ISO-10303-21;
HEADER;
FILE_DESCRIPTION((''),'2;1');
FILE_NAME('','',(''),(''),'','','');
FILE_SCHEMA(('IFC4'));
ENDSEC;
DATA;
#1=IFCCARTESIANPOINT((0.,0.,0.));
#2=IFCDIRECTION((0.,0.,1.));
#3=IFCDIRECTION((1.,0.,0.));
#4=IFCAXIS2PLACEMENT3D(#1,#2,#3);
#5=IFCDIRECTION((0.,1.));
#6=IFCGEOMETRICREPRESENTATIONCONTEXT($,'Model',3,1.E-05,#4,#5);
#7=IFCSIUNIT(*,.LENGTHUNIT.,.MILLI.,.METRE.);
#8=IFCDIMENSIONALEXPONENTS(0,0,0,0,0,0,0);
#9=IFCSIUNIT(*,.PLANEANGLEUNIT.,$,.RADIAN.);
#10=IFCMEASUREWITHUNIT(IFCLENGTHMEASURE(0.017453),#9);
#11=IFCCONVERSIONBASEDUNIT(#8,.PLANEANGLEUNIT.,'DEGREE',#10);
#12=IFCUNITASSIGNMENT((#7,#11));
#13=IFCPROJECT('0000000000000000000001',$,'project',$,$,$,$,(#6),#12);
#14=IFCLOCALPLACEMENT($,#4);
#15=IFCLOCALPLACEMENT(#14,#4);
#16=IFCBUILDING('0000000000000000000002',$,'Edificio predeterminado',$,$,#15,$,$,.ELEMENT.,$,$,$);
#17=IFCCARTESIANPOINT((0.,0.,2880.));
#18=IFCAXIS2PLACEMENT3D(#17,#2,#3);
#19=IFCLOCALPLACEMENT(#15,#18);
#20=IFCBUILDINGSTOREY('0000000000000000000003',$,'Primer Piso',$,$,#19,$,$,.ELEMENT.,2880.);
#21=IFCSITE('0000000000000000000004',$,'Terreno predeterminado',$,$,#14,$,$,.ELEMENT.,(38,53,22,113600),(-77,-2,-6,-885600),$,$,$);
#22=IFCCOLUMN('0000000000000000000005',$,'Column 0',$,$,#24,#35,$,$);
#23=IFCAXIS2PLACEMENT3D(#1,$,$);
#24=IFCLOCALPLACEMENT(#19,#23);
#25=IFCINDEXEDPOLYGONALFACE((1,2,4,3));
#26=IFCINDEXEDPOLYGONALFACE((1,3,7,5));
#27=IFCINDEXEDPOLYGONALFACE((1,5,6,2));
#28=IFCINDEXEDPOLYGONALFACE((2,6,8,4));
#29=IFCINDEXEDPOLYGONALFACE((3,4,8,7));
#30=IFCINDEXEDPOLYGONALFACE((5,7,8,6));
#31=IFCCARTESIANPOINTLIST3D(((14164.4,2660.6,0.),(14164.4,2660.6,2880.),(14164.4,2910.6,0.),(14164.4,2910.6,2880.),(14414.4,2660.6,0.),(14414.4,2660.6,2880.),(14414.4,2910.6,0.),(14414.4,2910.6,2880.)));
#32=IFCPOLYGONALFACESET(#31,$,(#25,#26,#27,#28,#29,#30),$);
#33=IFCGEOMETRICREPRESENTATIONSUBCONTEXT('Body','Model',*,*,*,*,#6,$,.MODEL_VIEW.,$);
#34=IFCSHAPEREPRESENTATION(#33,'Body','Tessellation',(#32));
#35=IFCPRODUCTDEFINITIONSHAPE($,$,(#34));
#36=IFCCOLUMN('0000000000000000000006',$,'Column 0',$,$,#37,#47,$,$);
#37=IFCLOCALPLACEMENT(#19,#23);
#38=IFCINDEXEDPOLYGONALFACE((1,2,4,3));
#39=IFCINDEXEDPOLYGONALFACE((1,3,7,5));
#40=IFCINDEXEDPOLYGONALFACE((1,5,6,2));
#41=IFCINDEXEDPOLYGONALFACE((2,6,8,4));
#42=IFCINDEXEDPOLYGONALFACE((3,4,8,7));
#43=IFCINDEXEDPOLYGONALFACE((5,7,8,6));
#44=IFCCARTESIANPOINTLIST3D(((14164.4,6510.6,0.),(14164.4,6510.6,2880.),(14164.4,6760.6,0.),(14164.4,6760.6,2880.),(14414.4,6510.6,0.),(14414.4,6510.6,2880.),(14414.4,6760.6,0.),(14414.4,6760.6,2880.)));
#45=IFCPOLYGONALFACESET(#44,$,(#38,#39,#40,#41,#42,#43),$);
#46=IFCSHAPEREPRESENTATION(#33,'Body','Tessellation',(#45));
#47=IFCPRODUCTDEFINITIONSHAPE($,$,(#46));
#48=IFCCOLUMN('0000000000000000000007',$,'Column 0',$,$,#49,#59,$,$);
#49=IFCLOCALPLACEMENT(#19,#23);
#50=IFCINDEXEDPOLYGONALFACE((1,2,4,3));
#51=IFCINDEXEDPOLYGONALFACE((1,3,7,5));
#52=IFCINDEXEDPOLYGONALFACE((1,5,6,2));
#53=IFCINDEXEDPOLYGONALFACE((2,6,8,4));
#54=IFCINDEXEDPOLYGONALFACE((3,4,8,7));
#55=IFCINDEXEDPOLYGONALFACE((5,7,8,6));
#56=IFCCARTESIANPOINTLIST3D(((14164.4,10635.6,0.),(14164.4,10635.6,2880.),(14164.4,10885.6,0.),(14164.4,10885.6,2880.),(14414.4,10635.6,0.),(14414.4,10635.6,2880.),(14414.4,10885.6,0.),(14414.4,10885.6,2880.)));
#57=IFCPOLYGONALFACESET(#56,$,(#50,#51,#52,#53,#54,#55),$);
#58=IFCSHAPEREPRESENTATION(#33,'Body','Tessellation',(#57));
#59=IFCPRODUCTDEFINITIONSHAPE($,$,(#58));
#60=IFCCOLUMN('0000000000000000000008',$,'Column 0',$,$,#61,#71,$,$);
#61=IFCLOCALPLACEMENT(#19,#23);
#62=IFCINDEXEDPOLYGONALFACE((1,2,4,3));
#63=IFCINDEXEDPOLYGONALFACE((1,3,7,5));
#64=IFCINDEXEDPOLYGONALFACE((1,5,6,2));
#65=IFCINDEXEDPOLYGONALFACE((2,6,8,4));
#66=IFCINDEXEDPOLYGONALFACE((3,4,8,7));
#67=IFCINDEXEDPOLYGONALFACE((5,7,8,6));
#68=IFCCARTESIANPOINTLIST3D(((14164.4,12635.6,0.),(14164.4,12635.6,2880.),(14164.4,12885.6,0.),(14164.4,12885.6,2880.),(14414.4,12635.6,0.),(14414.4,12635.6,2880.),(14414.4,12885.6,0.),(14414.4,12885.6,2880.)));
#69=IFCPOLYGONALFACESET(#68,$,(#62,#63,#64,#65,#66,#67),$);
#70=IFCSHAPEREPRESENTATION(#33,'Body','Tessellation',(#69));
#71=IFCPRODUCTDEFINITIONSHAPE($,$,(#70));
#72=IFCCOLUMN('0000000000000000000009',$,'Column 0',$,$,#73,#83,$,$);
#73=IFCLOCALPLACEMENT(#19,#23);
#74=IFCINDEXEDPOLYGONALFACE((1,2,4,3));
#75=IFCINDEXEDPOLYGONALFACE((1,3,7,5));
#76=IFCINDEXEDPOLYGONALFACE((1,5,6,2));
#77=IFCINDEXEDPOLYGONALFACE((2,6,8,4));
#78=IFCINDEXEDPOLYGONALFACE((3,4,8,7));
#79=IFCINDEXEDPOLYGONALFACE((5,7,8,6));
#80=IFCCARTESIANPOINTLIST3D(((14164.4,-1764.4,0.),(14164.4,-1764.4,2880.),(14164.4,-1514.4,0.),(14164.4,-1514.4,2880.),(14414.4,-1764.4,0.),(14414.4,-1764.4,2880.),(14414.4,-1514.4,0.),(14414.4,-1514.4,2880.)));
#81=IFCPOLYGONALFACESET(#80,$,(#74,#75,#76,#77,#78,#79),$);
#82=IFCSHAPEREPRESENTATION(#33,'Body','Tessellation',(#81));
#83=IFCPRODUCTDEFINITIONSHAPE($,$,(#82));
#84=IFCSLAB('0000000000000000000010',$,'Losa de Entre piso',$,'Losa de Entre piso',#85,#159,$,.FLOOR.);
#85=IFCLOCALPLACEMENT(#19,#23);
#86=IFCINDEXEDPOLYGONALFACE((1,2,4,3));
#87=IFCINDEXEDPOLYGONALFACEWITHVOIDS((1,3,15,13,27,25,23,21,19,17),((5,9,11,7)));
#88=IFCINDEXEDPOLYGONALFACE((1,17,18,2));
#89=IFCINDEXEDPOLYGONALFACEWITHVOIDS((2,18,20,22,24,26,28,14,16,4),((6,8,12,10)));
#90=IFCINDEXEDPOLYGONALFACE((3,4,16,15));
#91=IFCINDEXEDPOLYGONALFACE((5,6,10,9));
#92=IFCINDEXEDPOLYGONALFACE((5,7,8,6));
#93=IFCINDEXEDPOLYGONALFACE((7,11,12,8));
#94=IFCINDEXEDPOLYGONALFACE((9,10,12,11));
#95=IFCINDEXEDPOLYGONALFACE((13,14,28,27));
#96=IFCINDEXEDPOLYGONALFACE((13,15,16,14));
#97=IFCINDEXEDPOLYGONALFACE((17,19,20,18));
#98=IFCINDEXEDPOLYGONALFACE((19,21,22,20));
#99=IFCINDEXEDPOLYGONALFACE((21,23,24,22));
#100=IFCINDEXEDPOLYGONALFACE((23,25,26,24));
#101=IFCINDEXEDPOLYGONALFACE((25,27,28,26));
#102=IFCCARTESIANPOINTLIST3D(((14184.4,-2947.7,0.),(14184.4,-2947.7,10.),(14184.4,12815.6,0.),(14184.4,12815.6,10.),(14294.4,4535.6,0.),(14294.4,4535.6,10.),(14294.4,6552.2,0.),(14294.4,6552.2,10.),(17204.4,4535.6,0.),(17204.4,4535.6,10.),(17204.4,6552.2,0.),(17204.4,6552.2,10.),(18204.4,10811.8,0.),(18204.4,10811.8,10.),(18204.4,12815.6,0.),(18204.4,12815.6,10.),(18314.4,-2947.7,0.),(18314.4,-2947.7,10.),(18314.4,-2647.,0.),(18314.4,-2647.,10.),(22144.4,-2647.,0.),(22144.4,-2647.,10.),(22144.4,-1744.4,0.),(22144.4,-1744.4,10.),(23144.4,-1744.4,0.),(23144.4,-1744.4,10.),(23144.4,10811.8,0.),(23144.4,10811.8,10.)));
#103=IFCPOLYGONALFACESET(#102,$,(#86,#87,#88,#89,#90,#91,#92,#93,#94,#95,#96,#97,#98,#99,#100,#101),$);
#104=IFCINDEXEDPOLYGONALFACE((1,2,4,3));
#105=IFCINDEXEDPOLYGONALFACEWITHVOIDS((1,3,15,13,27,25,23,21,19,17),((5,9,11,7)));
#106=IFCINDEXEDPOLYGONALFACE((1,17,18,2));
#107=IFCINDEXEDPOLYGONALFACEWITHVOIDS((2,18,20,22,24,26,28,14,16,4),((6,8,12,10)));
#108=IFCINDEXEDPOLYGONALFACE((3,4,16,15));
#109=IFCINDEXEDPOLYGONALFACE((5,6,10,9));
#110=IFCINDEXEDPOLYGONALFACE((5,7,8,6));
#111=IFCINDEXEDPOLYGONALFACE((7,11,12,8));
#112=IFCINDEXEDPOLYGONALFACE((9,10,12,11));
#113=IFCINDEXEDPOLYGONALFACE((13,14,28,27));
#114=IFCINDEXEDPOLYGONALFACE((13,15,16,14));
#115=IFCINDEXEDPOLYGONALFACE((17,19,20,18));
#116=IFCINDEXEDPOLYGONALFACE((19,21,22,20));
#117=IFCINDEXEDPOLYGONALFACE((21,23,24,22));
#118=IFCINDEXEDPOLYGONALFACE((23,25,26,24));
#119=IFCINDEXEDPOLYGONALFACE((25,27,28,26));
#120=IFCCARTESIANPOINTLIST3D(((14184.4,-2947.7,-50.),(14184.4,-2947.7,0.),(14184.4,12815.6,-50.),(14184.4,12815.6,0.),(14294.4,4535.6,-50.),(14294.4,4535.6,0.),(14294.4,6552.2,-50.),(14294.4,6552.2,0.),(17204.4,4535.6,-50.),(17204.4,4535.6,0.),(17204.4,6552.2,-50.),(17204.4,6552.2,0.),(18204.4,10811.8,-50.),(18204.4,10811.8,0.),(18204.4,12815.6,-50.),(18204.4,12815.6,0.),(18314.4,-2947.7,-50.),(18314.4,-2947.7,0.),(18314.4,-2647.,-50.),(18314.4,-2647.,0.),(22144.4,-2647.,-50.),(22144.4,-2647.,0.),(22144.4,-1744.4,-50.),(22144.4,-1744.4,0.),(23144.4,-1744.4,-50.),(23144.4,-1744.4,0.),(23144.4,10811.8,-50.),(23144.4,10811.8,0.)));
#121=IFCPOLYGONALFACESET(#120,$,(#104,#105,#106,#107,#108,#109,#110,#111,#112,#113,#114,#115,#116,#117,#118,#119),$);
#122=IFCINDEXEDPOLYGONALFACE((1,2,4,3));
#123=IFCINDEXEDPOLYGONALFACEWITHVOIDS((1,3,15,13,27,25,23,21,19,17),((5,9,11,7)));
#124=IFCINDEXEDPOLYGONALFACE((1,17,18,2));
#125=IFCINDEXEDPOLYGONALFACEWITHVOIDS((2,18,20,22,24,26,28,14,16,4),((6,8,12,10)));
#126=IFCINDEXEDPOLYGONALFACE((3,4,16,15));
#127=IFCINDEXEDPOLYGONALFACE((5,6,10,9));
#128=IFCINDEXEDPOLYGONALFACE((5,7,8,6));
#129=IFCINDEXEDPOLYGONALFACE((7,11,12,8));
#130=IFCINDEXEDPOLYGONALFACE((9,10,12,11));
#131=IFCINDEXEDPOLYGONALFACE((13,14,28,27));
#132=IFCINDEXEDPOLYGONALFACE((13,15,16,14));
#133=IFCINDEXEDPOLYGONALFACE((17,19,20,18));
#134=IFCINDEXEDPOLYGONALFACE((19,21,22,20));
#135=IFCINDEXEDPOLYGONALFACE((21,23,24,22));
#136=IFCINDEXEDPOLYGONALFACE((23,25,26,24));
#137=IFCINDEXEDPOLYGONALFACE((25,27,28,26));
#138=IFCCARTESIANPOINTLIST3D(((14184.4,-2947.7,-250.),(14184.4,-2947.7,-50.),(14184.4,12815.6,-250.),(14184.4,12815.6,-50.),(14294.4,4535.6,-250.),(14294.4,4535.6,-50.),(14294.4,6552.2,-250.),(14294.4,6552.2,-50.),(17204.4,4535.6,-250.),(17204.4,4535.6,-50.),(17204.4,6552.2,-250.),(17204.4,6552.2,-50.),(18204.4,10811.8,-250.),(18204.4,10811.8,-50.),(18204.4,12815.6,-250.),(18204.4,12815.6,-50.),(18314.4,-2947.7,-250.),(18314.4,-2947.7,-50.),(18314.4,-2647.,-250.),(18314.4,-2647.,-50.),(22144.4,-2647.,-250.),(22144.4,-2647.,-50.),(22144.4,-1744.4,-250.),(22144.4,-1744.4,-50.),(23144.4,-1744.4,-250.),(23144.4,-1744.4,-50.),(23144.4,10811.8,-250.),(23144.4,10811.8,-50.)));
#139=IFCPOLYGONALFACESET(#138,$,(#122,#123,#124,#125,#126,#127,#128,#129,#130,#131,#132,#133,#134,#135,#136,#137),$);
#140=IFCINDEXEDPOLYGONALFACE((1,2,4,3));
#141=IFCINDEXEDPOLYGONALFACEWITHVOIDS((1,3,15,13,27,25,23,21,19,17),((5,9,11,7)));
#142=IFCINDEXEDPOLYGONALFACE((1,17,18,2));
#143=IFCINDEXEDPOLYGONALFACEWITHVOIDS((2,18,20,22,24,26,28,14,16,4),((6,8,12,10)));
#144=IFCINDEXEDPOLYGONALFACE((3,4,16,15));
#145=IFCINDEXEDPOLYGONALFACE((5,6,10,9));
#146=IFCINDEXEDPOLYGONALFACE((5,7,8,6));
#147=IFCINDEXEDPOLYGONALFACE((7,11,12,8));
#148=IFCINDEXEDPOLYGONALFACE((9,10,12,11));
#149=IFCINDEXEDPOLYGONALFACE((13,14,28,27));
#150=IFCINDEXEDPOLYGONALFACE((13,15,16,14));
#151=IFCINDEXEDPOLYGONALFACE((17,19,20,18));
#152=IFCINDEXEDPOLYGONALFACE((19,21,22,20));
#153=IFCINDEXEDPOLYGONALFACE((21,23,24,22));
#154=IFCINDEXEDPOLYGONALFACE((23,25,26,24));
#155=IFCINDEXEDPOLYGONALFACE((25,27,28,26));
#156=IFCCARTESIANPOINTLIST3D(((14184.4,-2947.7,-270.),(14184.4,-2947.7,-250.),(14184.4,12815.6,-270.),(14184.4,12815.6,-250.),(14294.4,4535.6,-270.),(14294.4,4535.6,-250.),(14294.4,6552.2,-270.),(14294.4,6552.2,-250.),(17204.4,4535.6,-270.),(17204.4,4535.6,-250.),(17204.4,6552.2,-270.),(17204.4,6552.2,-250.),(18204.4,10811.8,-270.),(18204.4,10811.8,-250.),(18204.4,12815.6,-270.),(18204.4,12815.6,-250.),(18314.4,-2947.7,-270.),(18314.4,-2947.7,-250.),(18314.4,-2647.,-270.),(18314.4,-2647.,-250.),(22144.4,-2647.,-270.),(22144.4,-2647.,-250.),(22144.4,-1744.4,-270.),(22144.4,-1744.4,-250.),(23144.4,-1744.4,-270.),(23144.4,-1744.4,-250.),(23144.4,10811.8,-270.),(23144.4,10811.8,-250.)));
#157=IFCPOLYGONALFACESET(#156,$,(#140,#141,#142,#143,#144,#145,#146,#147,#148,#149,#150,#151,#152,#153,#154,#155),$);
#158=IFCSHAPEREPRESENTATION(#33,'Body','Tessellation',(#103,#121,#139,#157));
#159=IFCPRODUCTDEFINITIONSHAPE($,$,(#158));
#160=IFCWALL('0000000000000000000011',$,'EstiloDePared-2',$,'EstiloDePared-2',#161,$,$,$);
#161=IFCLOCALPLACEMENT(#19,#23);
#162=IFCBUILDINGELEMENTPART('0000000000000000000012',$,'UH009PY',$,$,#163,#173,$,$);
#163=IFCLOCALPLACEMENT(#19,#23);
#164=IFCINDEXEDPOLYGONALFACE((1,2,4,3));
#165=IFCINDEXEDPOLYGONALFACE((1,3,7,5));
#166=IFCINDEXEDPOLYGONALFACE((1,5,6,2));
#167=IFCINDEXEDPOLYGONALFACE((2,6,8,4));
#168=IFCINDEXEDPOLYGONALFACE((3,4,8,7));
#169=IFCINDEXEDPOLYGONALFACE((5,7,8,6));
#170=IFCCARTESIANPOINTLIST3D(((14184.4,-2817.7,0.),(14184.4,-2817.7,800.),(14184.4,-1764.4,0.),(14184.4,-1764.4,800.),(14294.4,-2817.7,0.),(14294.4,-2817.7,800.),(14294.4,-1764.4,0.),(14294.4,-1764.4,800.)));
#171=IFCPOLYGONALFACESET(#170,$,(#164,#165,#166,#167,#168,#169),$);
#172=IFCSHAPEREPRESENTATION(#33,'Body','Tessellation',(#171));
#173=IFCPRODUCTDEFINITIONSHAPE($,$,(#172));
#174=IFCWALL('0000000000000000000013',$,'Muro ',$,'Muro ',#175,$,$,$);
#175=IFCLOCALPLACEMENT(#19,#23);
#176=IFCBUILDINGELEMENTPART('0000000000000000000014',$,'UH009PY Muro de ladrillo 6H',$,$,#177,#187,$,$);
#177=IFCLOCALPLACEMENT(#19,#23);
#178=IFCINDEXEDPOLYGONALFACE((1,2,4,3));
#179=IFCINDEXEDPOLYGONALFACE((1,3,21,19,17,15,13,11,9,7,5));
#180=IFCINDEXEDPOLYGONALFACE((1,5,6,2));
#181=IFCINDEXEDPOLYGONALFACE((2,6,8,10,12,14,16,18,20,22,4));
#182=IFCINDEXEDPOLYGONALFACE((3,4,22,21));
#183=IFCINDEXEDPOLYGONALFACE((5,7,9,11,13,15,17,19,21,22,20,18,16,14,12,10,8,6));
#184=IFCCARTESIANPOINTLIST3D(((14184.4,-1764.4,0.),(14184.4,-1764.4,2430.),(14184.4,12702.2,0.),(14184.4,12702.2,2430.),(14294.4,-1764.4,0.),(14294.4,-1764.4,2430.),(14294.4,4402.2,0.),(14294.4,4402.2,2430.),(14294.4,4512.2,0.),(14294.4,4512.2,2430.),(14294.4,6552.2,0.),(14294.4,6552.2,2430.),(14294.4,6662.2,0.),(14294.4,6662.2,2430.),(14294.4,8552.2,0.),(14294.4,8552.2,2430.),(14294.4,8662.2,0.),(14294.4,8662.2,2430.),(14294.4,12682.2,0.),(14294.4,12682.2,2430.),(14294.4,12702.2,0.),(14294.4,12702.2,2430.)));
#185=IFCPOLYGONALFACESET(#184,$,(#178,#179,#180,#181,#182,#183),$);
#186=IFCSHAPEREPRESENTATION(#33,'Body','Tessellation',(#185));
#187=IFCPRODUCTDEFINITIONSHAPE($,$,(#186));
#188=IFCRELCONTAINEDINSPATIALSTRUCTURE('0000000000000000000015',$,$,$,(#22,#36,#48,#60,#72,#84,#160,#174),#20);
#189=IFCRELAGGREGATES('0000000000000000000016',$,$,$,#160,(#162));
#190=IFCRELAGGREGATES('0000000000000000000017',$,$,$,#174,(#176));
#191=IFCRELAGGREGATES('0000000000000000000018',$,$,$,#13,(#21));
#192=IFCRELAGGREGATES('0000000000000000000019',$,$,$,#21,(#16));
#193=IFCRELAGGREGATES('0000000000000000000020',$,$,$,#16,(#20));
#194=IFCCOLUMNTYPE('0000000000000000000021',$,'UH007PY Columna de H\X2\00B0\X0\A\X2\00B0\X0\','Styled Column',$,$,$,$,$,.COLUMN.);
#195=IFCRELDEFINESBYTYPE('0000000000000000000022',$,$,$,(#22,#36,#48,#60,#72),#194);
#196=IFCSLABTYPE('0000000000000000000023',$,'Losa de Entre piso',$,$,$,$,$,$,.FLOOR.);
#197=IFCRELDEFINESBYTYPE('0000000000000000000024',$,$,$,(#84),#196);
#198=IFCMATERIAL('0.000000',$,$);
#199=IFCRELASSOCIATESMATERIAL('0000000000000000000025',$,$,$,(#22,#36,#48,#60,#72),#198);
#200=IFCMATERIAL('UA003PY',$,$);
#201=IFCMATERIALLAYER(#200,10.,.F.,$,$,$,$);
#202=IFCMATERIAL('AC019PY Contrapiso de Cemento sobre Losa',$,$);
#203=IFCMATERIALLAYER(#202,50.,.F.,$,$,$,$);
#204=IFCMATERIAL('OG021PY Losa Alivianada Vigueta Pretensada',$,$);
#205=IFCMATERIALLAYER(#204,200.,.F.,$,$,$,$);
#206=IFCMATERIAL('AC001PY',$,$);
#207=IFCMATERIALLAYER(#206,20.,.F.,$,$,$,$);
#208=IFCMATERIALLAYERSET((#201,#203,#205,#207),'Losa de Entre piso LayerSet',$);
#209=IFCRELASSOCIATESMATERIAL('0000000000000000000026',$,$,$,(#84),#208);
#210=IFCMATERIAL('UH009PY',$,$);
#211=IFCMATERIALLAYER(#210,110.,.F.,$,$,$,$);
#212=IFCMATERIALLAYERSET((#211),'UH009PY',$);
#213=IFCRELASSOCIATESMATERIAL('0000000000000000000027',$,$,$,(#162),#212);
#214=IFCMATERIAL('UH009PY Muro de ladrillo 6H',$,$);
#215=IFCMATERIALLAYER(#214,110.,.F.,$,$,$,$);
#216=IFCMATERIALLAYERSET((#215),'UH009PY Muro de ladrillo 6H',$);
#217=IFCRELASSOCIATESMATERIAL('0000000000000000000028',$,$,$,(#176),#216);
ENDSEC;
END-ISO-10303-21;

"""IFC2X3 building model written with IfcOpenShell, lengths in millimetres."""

from ifc_helpers import new_model, entity, si_unit, converted_unit, direction, frame, origin_with_axes, place, context, subcontext, project, spatial, polyline, outline, extrude, material, layer, layer_set, layer_usage, type_object, element, aggregate, save


model = new_model("IFC2X3")

# Units and contexts
model_context = context("Model", 3, precision=1e-05, world=origin_with_axes(), true_north=direction((0.0, 1.0)))
body_context = subcontext(model_context, "Body", "Model", "MODEL_VIEW")
ifc_project = project(units=[si_unit("LENGTHUNIT", "METRE", prefix="MILLI"), converted_unit("PLANEANGLEUNIT", "DEGREE", entity("IfcLengthMeasure", 0.017453), si_unit("PLANEANGLEUNIT", "RADIAN"), dimensions=[0, 0, 0, 0, 0, 0, 0])], contexts=[model_context])

# Site, building, storey
site_placement = place(None, origin_with_axes())
site = spatial("IfcSite", under=ifc_project, at=site_placement, Name="Terreno predeterminado", CompositionType="ELEMENT", RefLatitude=(38, 53, 22, 113600), RefLongitude=(-77, -2, -6, -885600))
building_placement = place(site_placement, origin_with_axes())
building = spatial("IfcBuilding", under=site, at=building_placement, Name="Edificio predeterminado", CompositionType="ELEMENT")
storey_placement = place(building_placement, frame((0.0, 0.0, 2880.0), z_axis=(0.0, 0.0, 1.0), x_axis=(1.0, 0.0, 0.0)))
storey = spatial("IfcBuildingStorey", under=building, at=storey_placement, Name="Primer Piso", CompositionType="ELEMENT", Elevation=2880.0)

# Columns
ifc_material_1 = material(Name="0.000000")
column_type = type_object("IfcColumnType", Name="UH007PY Columna de H°A°", Description="Styled Column", PredefinedType="COLUMN")
for number, where, z_axis, x_axis, name in (
    (1, (14289.4, 2785.6, 0.0), (0.0, 0.0, 1.0), (1.0, 0.0, 0.0), "Column 0"),
    (2, (14289.4, 6635.6, 0.0), (0.0, 0.0, 1.0), (1.0, 0.0, 0.0), "Column 0"),
    (3, (14289.4, 10760.6, 0.0), (0.0, 0.0, 1.0), (1.0, 0.0, 0.0), "Column 0"),
    (4, (14289.4, 12760.6, 0.0), (0.0, 0.0, 1.0), (1.0, 0.0, 0.0), "Column 0"),
    (5, (14289.4, -1639.4, 0.0), (0.0, 0.0, 1.0), (1.0, 0.0, 0.0), "Column 0"),
):
    element("IfcColumn", number, at=place(storey_placement, frame(where, z_axis=z_axis, x_axis=x_axis)), inside=storey, type_object=column_type, material=ifc_material_1, Name=name, context=body_context, shape_type="SweptSolid", body=[
        extrude(outline(polyline([(-125.0, -125.0), (125.0, -125.0), (125.0, 125.0), (-125.0, 125.0), (-125.0, -125.0)])), origin_with_axes(), (0.0, 0.0, 1.0), 2880.0),
    ])

# Slab
ifc_material_2 = material(Name="UA003PY")
ifc_layer_1 = layer(ifc_material_2, 10.0, ventilated=False)
ifc_material_3 = material(Name="AC019PY Contrapiso de Cemento sobre Losa")
ifc_layer_2 = layer(ifc_material_3, 50.0, ventilated=False)
ifc_material_4 = material(Name="OG021PY Losa Alivianada Vigueta Pretensada")
ifc_layer_3 = layer(ifc_material_4, 200.0, ventilated=False)
ifc_material_5 = material(Name="AC001PY")
ifc_layer_4 = layer(ifc_material_5, 20.0, ventilated=False)
ifc_layer_set_1 = layer_set([ifc_layer_1, ifc_layer_2, ifc_layer_3, ifc_layer_4], Name="Losa de Entre piso LayerSet")
ifc_layer_usage_1 = layer_usage(ifc_layer_set_1, "AXIS3", "NEGATIVE", 0.0)
slab_type = type_object("IfcSlabType", Name="Losa de Entre piso", PredefinedType="FLOOR")
slab_placement = place(storey_placement, frame((0.0, 0.0, -2880.0), z_axis=(0.0, 0.0, 1.0), x_axis=(1.0, 0.0, 0.0)))
element("IfcSlab", 6, at=slab_placement, inside=storey, type_object=slab_type, material=ifc_layer_usage_1, Name="Losa de Entre piso", ObjectType="Losa de Entre piso", PredefinedType="FLOOR", context=body_context, shape_type="SweptSolid", body=[
    extrude(outline(polyline([(0.0, 15763.4), (4130.0, 15763.4), (4130.0, 15462.6), (7960.0, 15462.6), (7960.0, 14560.0), (8960.0, 14560.0), (8960.0, 2003.8), (4020.0, 2003.8), (4020.0, 0.0), (0.0, 0.0), (0.0, 15763.4)]), holes=[polyline([(110.0, 6263.4), (3020.0, 6263.4), (3020.0, 8280.0), (110.0, 8280.0), (110.0, 6263.4)])]), frame((14184.4, 12815.6, 2880.0), z_axis=(0.0, 0.0, -1.0), x_axis=(1.0, 0.0, 0.0)), (0.0, 0.0, -1.0), 10.0),
    extrude(outline(polyline([(0.0, 15763.4), (4130.0, 15763.4), (4130.0, 15462.6), (7960.0, 15462.6), (7960.0, 14560.0), (8960.0, 14560.0), (8960.0, 2003.8), (4020.0, 2003.8), (4020.0, 0.0), (0.0, 0.0), (0.0, 15763.4)]), holes=[polyline([(110.0, 6263.4), (3020.0, 6263.4), (3020.0, 8280.0), (110.0, 8280.0), (110.0, 6263.4)])]), frame((14184.4, 12815.6, 2830.0), z_axis=(0.0, 0.0, -1.0), x_axis=(1.0, 0.0, 0.0)), (0.0, 0.0, -1.0), 50.0),
    extrude(outline(polyline([(0.0, 15763.4), (4130.0, 15763.4), (4130.0, 15462.6), (7960.0, 15462.6), (7960.0, 14560.0), (8960.0, 14560.0), (8960.0, 2003.8), (4020.0, 2003.8), (4020.0, 0.0), (0.0, 0.0), (0.0, 15763.4)]), holes=[polyline([(110.0, 6263.4), (3020.0, 6263.4), (3020.0, 8280.0), (110.0, 8280.0), (110.0, 6263.4)])]), frame((14184.4, 12815.6, 2630.0), z_axis=(0.0, 0.0, -1.0), x_axis=(1.0, 0.0, 0.0)), (0.0, 0.0, -1.0), 200.0),
    extrude(outline(polyline([(0.0, 15763.4), (4130.0, 15763.4), (4130.0, 15462.6), (7960.0, 15462.6), (7960.0, 14560.0), (8960.0, 14560.0), (8960.0, 2003.8), (4020.0, 2003.8), (4020.0, 0.0), (0.0, 0.0), (0.0, 15763.4)]), holes=[polyline([(110.0, 6263.4), (3020.0, 6263.4), (3020.0, 8280.0), (110.0, 8280.0), (110.0, 6263.4)])]), frame((14184.4, 12815.6, 2610.0), z_axis=(0.0, 0.0, -1.0), x_axis=(1.0, 0.0, 0.0)), (0.0, 0.0, -1.0), 20.0),
])

# Walls, building element parts
wall_1_placement = place(storey_placement, frame((14239.4, -2817.7, 0.0), z_axis=(0.0, 0.0, 1.0), x_axis=(0.0, 1.0, 0.0)))
wall_1 = element("IfcWall", 7, at=wall_1_placement, inside=storey, Name="EstiloDePared-2", ObjectType="EstiloDePared-2")
ifc_material_6 = material(Name="UH009PY")
ifc_layer_5 = layer(ifc_material_6, 110.0, ventilated=False)
ifc_layer_set_2 = layer_set([ifc_layer_5], Name="UH009PY")
ifc_layer_usage_2 = layer_usage(ifc_layer_set_2, "AXIS2", "NEGATIVE", -55.0)
building_element_part_1_placement = place(wall_1_placement, origin_with_axes())
building_element_part_1 = element("IfcBuildingElementPart", 8, at=building_element_part_1_placement, material=ifc_layer_usage_2, Name="UH009PY", context=body_context, shape_type="SweptSolid", body=[
    extrude(outline(polyline([(1053.4, 55.0), (1053.4, -55.0), (0.0, -55.0), (0.0, 55.0), (1053.4, 55.0)])), origin_with_axes(), (0.0, 0.0, 1.0), 800.0),
])
aggregate(wall_1, [building_element_part_1])
wall_2_placement = place(storey_placement, frame((14239.4, -1764.4, 0.0), z_axis=(0.0, 0.0, 1.0), x_axis=(0.0, 1.0, 0.0)))
wall_2 = element("IfcWall", 9, at=wall_2_placement, inside=storey, Name="Muro ", ObjectType="Muro ")
ifc_material_7 = material(Name="UH009PY Muro de ladrillo 6H")
ifc_layer_6 = layer(ifc_material_7, 110.0, ventilated=False)
ifc_layer_set_3 = layer_set([ifc_layer_6], Name="UH009PY Muro de ladrillo 6H")
ifc_layer_usage_3 = layer_usage(ifc_layer_set_3, "AXIS2", "NEGATIVE", -55.0)
building_element_part_2_placement = place(wall_2_placement, origin_with_axes())
building_element_part_2 = element("IfcBuildingElementPart", 10, at=building_element_part_2_placement, material=ifc_layer_usage_3, Name="UH009PY Muro de ladrillo 6H", context=body_context, shape_type="SweptSolid", body=[
    extrude(outline(polyline([(14466.6, 55.0), (14466.6, -55.0), (14446.6, -55.0), (10426.6, -55.0), (10316.6, -55.0), (8426.6, -55.0), (8316.6, -55.0), (6276.6, -55.0), (6166.6, -55.0), (0.0, -55.0), (0.0, 55.0), (14466.6, 55.0)])), origin_with_axes(), (0.0, 0.0, 1.0), 2430.0),
])
aggregate(wall_2, [building_element_part_2])

save(model, "model.ifc")
